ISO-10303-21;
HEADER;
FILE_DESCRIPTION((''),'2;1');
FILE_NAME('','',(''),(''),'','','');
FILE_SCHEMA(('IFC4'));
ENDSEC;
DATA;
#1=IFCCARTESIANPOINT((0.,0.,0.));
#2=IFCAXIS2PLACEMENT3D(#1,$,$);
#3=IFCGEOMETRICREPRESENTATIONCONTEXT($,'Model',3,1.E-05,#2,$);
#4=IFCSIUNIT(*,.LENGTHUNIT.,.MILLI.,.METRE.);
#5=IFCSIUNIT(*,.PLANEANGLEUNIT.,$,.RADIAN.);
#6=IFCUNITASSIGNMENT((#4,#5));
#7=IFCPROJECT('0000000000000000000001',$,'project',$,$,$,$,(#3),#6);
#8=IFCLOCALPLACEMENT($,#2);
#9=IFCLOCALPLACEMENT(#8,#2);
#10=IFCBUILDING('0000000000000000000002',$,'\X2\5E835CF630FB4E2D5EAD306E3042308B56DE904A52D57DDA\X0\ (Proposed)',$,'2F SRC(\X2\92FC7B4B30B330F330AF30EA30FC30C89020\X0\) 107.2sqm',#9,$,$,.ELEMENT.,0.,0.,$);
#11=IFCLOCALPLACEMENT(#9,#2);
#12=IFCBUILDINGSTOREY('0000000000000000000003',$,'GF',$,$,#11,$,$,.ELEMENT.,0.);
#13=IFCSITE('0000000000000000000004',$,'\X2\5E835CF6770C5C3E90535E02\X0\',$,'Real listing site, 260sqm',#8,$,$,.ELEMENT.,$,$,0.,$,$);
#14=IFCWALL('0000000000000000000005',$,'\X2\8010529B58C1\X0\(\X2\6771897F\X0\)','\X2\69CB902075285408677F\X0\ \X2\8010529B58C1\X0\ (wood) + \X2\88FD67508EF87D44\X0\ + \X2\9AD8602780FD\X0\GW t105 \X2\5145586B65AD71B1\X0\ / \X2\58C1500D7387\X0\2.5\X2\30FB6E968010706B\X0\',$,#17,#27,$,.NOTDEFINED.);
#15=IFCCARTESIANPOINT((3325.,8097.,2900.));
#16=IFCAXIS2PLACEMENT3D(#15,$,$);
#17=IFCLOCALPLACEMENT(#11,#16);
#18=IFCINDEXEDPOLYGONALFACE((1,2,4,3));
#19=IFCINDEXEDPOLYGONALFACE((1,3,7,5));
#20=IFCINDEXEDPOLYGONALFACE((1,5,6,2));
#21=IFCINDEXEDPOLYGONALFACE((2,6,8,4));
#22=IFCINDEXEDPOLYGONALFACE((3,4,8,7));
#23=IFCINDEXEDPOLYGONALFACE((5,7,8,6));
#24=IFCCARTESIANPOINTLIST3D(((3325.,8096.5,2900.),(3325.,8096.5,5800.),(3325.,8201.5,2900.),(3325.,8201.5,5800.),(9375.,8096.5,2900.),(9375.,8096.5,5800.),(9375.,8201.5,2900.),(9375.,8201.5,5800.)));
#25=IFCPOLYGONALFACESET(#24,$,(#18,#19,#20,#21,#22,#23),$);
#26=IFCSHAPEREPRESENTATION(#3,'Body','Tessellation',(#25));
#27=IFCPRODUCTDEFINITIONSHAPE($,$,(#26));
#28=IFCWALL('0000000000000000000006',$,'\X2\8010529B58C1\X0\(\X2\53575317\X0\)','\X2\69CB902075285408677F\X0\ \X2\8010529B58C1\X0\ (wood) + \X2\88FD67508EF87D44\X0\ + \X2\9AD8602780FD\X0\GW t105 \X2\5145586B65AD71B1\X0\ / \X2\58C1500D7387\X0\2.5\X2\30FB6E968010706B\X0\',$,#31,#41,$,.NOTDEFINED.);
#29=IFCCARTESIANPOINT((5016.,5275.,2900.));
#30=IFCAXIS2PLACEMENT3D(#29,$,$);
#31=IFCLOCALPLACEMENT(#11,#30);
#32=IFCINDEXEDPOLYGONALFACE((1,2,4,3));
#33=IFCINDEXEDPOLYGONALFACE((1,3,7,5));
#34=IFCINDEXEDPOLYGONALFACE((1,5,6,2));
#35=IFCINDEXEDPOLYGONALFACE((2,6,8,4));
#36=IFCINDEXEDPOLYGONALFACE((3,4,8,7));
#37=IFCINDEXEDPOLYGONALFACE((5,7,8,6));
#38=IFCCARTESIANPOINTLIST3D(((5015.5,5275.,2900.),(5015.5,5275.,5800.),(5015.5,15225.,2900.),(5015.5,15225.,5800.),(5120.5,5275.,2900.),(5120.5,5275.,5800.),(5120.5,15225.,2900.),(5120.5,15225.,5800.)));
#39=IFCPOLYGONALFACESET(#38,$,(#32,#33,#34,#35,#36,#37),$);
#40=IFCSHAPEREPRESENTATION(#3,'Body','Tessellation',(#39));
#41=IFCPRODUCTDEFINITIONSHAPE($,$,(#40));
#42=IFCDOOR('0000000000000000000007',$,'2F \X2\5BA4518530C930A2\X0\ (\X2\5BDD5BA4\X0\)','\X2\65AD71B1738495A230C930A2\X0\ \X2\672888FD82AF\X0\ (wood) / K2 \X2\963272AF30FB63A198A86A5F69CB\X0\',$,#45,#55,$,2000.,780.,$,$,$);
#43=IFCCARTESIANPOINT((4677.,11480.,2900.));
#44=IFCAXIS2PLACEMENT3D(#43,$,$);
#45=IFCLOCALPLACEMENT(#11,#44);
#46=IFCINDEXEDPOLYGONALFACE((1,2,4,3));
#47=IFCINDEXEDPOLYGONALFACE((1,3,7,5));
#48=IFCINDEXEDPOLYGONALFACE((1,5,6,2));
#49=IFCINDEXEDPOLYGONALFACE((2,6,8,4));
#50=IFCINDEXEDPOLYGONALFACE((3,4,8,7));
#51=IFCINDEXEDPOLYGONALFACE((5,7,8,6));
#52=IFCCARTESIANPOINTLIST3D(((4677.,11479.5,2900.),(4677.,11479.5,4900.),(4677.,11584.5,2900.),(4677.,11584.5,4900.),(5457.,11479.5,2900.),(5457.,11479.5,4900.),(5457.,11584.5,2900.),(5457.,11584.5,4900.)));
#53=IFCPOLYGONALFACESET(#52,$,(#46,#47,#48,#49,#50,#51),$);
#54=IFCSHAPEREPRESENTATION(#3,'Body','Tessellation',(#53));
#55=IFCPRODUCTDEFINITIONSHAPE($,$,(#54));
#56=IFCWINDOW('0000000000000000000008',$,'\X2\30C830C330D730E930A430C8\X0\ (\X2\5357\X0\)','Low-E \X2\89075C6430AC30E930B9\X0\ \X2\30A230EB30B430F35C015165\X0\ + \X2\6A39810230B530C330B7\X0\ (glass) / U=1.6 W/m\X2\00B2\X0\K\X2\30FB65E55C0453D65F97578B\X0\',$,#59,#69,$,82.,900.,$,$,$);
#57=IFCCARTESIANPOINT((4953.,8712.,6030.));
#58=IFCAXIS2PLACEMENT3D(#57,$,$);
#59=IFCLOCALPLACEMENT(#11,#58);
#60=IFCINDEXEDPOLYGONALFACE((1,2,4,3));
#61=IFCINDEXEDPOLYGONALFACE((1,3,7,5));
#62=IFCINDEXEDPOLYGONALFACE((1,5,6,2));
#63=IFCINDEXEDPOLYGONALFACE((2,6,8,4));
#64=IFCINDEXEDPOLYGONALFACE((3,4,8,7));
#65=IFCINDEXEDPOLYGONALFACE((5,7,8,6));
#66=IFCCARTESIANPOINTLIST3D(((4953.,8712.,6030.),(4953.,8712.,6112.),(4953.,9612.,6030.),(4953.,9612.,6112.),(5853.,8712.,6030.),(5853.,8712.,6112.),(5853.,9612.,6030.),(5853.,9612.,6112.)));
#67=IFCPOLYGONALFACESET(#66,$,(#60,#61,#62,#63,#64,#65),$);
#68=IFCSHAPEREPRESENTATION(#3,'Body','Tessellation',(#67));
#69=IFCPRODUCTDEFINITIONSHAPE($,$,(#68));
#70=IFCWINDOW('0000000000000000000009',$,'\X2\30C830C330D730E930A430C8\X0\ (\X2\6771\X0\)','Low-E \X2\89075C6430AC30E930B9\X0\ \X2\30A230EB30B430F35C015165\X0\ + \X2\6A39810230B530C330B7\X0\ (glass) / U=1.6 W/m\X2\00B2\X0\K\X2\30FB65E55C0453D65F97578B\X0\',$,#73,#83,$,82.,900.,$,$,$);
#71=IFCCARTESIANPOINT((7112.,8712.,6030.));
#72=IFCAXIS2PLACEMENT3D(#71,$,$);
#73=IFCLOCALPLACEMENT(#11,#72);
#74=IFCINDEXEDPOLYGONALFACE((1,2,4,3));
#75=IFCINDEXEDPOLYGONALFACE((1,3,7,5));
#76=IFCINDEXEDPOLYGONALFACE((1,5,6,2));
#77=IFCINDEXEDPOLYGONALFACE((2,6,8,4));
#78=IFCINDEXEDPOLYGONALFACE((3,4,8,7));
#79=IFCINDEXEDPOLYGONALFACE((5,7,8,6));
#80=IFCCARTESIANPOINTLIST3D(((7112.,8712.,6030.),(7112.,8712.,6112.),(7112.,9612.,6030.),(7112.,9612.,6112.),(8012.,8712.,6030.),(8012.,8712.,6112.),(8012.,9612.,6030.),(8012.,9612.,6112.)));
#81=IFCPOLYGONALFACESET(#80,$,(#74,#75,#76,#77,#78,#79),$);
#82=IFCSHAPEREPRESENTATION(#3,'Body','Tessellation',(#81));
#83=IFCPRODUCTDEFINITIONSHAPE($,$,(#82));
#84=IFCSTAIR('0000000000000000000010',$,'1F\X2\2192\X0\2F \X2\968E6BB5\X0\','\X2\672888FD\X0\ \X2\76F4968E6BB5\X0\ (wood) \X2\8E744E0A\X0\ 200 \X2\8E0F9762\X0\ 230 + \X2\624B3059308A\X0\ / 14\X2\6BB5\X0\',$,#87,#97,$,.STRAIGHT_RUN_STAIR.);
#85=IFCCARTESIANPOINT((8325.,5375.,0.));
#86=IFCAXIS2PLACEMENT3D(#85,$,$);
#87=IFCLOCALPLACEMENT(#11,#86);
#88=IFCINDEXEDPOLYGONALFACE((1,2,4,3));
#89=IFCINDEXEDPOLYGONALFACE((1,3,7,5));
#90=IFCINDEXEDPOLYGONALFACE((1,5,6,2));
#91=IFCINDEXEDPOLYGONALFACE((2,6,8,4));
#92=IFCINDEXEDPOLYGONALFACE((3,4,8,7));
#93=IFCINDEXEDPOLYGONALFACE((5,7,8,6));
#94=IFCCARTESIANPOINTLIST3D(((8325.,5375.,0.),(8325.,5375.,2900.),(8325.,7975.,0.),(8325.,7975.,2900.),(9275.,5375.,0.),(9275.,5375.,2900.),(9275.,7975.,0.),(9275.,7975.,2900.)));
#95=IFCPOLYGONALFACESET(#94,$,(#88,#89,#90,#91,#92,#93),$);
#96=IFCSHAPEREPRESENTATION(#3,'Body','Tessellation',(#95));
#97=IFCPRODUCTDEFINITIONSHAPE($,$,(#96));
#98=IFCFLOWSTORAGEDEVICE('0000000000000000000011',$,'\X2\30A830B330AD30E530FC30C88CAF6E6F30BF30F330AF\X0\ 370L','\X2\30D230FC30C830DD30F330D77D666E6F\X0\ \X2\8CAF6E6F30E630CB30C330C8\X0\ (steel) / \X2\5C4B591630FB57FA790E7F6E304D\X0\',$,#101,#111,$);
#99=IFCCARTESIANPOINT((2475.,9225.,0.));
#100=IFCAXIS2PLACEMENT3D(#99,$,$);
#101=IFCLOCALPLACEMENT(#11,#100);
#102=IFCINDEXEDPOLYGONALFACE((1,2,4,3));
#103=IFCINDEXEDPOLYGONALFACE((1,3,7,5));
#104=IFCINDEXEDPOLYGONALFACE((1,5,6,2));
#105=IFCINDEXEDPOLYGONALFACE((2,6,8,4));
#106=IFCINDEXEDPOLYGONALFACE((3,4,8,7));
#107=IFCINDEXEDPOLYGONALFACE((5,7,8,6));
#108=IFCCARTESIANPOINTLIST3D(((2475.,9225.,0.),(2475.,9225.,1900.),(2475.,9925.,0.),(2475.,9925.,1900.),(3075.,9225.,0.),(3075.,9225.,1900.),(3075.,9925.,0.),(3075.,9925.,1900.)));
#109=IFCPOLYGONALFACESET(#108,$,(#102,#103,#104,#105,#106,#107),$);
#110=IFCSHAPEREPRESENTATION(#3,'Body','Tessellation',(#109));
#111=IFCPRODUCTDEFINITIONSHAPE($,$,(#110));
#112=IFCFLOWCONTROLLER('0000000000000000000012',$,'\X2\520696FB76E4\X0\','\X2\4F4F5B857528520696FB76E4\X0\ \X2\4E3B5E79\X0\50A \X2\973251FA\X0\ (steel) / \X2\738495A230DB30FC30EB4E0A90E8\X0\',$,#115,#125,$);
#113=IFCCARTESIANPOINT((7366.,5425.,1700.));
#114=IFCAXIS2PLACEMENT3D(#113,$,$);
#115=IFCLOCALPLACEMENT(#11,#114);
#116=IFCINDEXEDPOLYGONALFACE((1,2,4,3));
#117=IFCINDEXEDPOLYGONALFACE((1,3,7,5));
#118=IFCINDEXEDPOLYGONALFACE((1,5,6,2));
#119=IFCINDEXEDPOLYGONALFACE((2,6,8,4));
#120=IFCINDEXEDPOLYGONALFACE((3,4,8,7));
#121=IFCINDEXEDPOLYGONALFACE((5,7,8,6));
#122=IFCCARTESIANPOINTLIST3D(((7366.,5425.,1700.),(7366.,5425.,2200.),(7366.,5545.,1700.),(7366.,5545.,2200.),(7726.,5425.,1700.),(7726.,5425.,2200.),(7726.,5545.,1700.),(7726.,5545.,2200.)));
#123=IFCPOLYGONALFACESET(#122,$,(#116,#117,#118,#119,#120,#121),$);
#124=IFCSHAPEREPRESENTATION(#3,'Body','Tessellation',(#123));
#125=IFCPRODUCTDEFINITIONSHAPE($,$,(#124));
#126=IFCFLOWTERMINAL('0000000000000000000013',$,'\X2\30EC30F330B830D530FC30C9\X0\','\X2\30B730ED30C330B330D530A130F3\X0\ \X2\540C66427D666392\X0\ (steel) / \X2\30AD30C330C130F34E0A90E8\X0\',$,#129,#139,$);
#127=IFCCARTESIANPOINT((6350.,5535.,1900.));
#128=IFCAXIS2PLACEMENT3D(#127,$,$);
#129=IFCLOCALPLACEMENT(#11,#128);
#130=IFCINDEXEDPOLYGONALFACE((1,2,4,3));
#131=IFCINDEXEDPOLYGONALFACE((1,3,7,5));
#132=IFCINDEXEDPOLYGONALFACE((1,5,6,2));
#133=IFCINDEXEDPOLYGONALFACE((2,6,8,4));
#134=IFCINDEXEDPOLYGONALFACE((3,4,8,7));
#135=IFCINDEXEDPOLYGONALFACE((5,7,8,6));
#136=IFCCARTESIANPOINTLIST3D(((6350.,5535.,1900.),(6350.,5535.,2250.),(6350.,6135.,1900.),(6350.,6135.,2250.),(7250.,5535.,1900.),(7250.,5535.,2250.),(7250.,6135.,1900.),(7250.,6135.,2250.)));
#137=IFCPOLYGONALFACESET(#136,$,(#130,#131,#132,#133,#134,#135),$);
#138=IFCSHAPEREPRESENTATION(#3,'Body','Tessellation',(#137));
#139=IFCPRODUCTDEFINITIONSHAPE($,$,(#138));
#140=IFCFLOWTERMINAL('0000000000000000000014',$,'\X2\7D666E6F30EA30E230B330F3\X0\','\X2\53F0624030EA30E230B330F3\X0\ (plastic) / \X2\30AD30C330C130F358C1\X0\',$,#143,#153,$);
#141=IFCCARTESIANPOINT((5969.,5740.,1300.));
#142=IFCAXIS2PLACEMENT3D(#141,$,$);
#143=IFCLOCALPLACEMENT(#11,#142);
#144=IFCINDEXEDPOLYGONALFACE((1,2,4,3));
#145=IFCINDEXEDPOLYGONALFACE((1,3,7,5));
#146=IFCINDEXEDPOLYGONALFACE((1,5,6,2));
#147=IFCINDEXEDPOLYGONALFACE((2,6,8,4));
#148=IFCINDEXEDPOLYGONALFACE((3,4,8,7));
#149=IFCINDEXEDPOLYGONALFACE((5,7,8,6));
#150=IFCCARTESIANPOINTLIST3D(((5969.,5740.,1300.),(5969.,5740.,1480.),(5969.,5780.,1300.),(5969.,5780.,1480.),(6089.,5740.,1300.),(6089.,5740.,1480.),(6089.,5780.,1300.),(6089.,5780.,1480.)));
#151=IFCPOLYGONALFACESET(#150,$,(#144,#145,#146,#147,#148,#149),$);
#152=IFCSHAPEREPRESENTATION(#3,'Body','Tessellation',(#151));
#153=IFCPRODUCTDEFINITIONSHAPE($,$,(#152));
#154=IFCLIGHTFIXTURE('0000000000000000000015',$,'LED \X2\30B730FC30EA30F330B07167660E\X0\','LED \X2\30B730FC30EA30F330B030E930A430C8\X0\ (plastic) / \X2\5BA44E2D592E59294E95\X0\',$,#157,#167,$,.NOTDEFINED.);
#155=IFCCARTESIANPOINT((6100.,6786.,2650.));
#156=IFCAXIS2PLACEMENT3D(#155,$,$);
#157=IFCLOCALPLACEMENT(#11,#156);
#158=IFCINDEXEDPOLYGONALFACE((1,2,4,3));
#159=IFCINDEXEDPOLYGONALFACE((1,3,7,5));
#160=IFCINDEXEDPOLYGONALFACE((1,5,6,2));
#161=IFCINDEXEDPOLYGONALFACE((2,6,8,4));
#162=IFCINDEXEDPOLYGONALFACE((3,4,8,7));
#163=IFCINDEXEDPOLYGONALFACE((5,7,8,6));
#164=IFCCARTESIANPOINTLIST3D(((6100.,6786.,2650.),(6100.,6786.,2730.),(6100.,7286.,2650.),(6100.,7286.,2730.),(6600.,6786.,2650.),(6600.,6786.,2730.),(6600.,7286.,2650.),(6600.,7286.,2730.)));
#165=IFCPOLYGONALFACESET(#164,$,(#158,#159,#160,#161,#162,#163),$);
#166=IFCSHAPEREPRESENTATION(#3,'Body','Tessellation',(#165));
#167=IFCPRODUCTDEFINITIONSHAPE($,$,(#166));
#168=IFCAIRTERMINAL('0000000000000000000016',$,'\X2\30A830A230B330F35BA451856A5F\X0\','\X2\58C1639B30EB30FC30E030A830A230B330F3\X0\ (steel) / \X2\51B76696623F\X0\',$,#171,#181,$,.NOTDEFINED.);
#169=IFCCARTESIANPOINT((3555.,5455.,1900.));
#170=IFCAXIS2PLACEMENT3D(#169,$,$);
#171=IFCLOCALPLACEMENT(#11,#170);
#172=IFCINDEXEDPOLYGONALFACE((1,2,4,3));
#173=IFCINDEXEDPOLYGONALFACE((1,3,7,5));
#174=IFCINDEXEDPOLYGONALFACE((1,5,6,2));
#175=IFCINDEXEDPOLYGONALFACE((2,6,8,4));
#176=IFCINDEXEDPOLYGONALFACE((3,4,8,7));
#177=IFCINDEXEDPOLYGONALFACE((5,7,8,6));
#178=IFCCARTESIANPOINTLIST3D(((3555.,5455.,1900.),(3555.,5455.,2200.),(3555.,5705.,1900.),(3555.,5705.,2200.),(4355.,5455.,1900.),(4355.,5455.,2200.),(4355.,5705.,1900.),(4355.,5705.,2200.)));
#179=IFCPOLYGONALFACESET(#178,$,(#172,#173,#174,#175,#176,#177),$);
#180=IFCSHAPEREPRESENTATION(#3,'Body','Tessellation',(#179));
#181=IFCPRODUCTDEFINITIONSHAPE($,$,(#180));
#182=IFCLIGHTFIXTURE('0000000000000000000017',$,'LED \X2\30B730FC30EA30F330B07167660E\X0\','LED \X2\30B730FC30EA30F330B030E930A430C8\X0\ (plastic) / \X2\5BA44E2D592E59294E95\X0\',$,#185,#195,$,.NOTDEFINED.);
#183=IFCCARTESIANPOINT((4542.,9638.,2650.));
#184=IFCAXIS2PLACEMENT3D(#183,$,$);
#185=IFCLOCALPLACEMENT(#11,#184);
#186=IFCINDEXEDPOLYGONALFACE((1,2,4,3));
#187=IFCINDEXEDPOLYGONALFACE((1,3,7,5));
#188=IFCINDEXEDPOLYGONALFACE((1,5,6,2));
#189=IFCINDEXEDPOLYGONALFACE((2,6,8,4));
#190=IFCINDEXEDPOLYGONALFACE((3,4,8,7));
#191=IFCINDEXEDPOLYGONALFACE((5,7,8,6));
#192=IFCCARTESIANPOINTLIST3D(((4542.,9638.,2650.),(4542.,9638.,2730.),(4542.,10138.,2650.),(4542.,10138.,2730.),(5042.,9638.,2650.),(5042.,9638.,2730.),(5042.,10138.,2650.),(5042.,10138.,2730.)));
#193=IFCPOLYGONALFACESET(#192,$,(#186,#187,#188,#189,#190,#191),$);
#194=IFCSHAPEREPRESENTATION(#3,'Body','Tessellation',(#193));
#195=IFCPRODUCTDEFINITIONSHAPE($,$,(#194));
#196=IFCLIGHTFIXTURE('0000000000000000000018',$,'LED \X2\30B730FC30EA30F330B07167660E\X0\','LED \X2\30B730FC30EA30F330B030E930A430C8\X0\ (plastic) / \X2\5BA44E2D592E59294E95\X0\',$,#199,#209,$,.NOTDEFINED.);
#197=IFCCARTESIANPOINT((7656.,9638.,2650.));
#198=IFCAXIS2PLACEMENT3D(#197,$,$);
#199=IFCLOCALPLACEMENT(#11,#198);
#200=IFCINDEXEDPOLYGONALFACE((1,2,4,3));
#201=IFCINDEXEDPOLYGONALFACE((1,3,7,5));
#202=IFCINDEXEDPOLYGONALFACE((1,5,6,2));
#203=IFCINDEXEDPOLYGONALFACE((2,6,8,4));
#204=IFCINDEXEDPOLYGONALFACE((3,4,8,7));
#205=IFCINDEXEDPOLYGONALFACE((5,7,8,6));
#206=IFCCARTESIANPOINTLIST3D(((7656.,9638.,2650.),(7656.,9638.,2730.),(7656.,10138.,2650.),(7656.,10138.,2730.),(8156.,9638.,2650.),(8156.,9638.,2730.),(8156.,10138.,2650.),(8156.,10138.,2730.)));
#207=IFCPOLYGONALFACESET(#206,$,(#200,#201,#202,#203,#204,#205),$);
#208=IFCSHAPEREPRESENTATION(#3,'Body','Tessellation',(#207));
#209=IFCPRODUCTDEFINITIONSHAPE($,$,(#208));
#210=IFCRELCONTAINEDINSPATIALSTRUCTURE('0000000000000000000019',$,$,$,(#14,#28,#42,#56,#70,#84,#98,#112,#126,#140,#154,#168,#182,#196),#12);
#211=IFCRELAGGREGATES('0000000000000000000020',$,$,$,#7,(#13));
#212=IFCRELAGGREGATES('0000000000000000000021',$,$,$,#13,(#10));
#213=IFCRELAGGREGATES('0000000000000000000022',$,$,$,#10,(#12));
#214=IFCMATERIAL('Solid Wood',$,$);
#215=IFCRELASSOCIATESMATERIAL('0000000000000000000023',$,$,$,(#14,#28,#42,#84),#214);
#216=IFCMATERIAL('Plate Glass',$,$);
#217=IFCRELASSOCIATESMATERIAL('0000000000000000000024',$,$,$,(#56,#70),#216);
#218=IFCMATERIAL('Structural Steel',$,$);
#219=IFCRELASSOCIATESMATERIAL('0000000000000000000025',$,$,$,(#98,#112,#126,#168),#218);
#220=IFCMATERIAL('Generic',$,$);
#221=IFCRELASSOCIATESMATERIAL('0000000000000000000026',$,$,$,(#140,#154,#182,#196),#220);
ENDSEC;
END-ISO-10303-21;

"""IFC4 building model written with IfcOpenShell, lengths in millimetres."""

from ifc_helpers import new_model, si_unit, frame, frame_2d, origin, place, context, project, spatial, rectangle, extrude, material, element, fill, save


model = new_model("IFC4")

# Units and contexts
model_context = context("Model", 3, precision=1e-05, world=origin())
ifc_project = project(units=[si_unit("LENGTHUNIT", "METRE", prefix="MILLI"), si_unit("PLANEANGLEUNIT", "RADIAN")], contexts=[model_context])

# Site, building, storey
site_placement = place(None, origin())
site = spatial("IfcSite", under=ifc_project, at=site_placement, Name="広島県尾道市", ObjectType="Real listing site, 260sqm", CompositionType="ELEMENT", RefElevation=0.0)
building_placement = place(site_placement, origin())
building = spatial("IfcBuilding", under=site, at=building_placement, Name="広島・中庭のある回遊動線 (Proposed)", ObjectType="2F SRC(鋼筋コンクリート造) 107.2sqm", CompositionType="ELEMENT", ElevationOfRefHeight=0.0, ElevationOfTerrain=0.0)
storey_placement = place(building_placement, origin())
storey = spatial("IfcBuildingStorey", under=building, at=storey_placement, Name="GF", CompositionType="ELEMENT", Elevation=0.0)

# Shared definitions
ifc_material_1 = material(Name="Solid Wood")

# Wall
wall_1_placement = place(storey_placement, frame((3325.0, 8097.0, 2900.0)))
element("IfcWall", 1, at=wall_1_placement, inside=storey, material=ifc_material_1, Name="耐力壁(東西)", Description="構造用合板 耐力壁 (wood) + 製材軸組 + 高性能GW t105 充填断熱 / 壁倍率2.5・準耐火", PredefinedType="NOTDEFINED", context=model_context, shape_type="SweptSolid", body=[
    extrude(rectangle(XDim=6050.0, YDim=105.0, at=frame_2d((3025.0, 52.0))), frame((3325.0, 8097.0, 2900.0)), (0.0, 0.0, 1.0), 2900.0),
])

# Wall, opening, door
wall_2_placement = place(storey_placement, frame((5016.0, 5275.0, 2900.0)))
wall_2 = element("IfcWall", 2, at=wall_2_placement, inside=storey, material=ifc_material_1, Name="耐力壁(南北)", Description="構造用合板 耐力壁 (wood) + 製材軸組 + 高性能GW t105 充填断熱 / 壁倍率2.5・準耐火", PredefinedType="NOTDEFINED", context=model_context, shape_type="SweptSolid", body=[
    extrude(rectangle(XDim=105.0, YDim=9950.0, at=frame_2d((52.0, 4975.0))), frame((5016.0, 5275.0, 2900.0)), (0.0, 0.0, 1.0), 2900.0),
])
opening_placement = place(storey_placement, frame((4677.0, 11480.0, 2900.0)))
opening = element("IfcOpeningElement", 3, at=opening_placement, cuts=wall_2, PredefinedType="NOTDEFINED", context=model_context, shape_type="SweptSolid", body=[
    extrude(rectangle(XDim=780.0, YDim=105.0, at=frame_2d((390.0, 52.0))), frame((4677.0, 11480.0, 2900.0)), (0.0, 0.0, 1.0), 2000.0),
])
door_placement = place(storey_placement, frame((4677.0, 11480.0, 2900.0)))
door = element("IfcDoor", 4, at=door_placement, inside=storey, material=ifc_material_1, Name="2F 室内ドア (寝室)", Description="断熱玄関ドア 木製芯 (wood) / K2 防犯・採風機構", OverallHeight=2000.0, OverallWidth=780.0, context=model_context, shape_type="SweptSolid", body=[
    extrude(rectangle(XDim=780.0, YDim=105.0, at=frame_2d((390.0, 52.0))), frame((4677.0, 11480.0, 2900.0)), (0.0, 0.0, 1.0), 2000.0),
])
fill(opening, door)

# Windows
ifc_material_2 = material(Name="Plate Glass")
window_1_placement = place(storey_placement, frame((4953.0, 8712.0, 6030.0)))
element("IfcWindow", 5, at=window_1_placement, inside=storey, material=ifc_material_2, Name="トップライト (南)", Description="Low-E 複層ガラス アルゴン封入 + 樹脂サッシ (glass) / U=1.6 W/m²K・日射取得型", OverallHeight=82.0, OverallWidth=900.0, context=model_context, shape_type="SweptSolid", body=[
    extrude(rectangle(XDim=900.0, YDim=900.0, at=frame_2d((450.0, 450.0))), frame((4953.0, 8712.0, 6030.0)), (0.0, 0.0, 1.0), 82.0),
])
window_2_placement = place(storey_placement, frame((7112.0, 8712.0, 6030.0)))
element("IfcWindow", 6, at=window_2_placement, inside=storey, material=ifc_material_2, Name="トップライト (東)", Description="Low-E 複層ガラス アルゴン封入 + 樹脂サッシ (glass) / U=1.6 W/m²K・日射取得型", OverallHeight=82.0, OverallWidth=900.0, context=model_context, shape_type="SweptSolid", body=[
    extrude(rectangle(XDim=900.0, YDim=900.0, at=frame_2d((450.0, 450.0))), frame((7112.0, 8712.0, 6030.0)), (0.0, 0.0, 1.0), 82.0),
])

# Stair
stair_placement = place(storey_placement, frame((8325.0, 5375.0, 0.0)))
element("IfcStair", 7, at=stair_placement, inside=storey, material=ifc_material_1, Name="1F→2F 階段", Description="木製 直階段 (wood) 蹴上 200 踏面 230 + 手すり / 14段", PredefinedType="STRAIGHT_RUN_STAIR", context=model_context, shape_type="SweptSolid", body=[
    extrude(rectangle(XDim=950.0, YDim=2600.0, at=frame_2d((475.0, 1300.0))), frame((8325.0, 5375.0, 0.0)), (0.0, 0.0, 1.0), 2900.0),
])

# Flow storage device
ifc_material_3 = material(Name="Structural Steel")
flow_storage_device_placement = place(storey_placement, frame((2475.0, 9225.0, 0.0)))
element("IfcFlowStorageDevice", 8, at=flow_storage_device_placement, inside=storey, material=ifc_material_3, Name="エコキュート貯湯タンク 370L", Description="ヒートポンプ給湯 貯湯ユニット (steel) / 屋外・基礎置き", context=model_context, shape_type="SweptSolid", body=[
    extrude(rectangle(XDim=600.0, YDim=700.0, at=frame_2d((300.0, 350.0))), frame((2475.0, 9225.0, 0.0)), (0.0, 0.0, 1.0), 1900.0),
])

# Flow controller
flow_controller_placement = place(storey_placement, frame((7366.0, 5425.0, 1700.0)))
element("IfcFlowController", 9, at=flow_controller_placement, inside=storey, material=ifc_material_3, Name="分電盤", Description="住宅用分電盤 主幹50A 露出 (steel) / 玄関ホール上部", context=model_context, shape_type="SweptSolid", body=[
    extrude(rectangle(XDim=360.0, YDim=120.0, at=frame_2d((180.0, 60.0))), frame((7366.0, 5425.0, 1700.0)), (0.0, 0.0, 1.0), 500.0),
])

# Flow terminals
flow_terminal_1_placement = place(storey_placement, frame((6350.0, 5535.0, 1900.0)))
element("IfcFlowTerminal", 10, at=flow_terminal_1_placement, inside=storey, material=ifc_material_3, Name="レンジフード", Description="シロッコファン 同時給排 (steel) / キッチン上部", context=model_context, shape_type="SweptSolid", body=[
    extrude(rectangle(XDim=900.0, YDim=600.0, at=frame_2d((450.0, 300.0))), frame((6350.0, 5535.0, 1900.0)), (0.0, 0.0, 1.0), 350.0),
])
ifc_material_4 = material(Name="Generic")
flow_terminal_2_placement = place(storey_placement, frame((5969.0, 5740.0, 1300.0)))
element("IfcFlowTerminal", 11, at=flow_terminal_2_placement, inside=storey, material=ifc_material_4, Name="給湯リモコン", Description="台所リモコン (plastic) / キッチン壁", context=model_context, shape_type="SweptSolid", body=[
    extrude(rectangle(XDim=120.0, YDim=40.0, at=frame_2d((60.0, 20.0))), frame((5969.0, 5740.0, 1300.0)), (0.0, 0.0, 1.0), 180.0),
])

# Light fixture
light_fixture_1_placement = place(storey_placement, frame((6100.0, 6786.0, 2650.0)))
element("IfcLightFixture", 12, at=light_fixture_1_placement, inside=storey, material=ifc_material_4, Name="LED シーリング照明", Description="LED シーリングライト (plastic) / 室中央天井", PredefinedType="NOTDEFINED", context=model_context, shape_type="SweptSolid", body=[
    extrude(rectangle(XDim=500.0, YDim=500.0, at=frame_2d((250.0, 250.0))), frame((6100.0, 6786.0, 2650.0)), (0.0, 0.0, 1.0), 80.0),
])

# Air terminal
air_terminal_1_placement = place(storey_placement, frame((3555.0, 5455.0, 1900.0)))
element("IfcAirTerminal", 13, at=air_terminal_1_placement, inside=storey, material=ifc_material_3, Name="エアコン室内機", Description="壁掛ルームエアコン (steel) / 冷暖房", PredefinedType="NOTDEFINED", context=model_context, shape_type="SweptSolid", body=[
    extrude(rectangle(XDim=800.0, YDim=250.0, at=frame_2d((400.0, 125.0))), frame((3555.0, 5455.0, 1900.0)), (0.0, 0.0, 1.0), 300.0),
])

# Light fixtures
light_fixture_2_placement = place(storey_placement, frame((4542.0, 9638.0, 2650.0)))
element("IfcLightFixture", 14, at=light_fixture_2_placement, inside=storey, material=ifc_material_4, Name="LED シーリング照明", Description="LED シーリングライト (plastic) / 室中央天井", PredefinedType="NOTDEFINED", context=model_context, shape_type="SweptSolid", body=[
    extrude(rectangle(XDim=500.0, YDim=500.0, at=frame_2d((250.0, 250.0))), frame((4542.0, 9638.0, 2650.0)), (0.0, 0.0, 1.0), 80.0),
])
light_fixture_3_placement = place(storey_placement, frame((7656.0, 9638.0, 2650.0)))
element("IfcLightFixture", 15, at=light_fixture_3_placement, inside=storey, material=ifc_material_4, Name="LED シーリング照明", Description="LED シーリングライト (plastic) / 室中央天井", PredefinedType="NOTDEFINED", context=model_context, shape_type="SweptSolid", body=[
    extrude(rectangle(XDim=500.0, YDim=500.0, at=frame_2d((250.0, 250.0))), frame((7656.0, 9638.0, 2650.0)), (0.0, 0.0, 1.0), 80.0),
])

save(model, "model.ifc")
